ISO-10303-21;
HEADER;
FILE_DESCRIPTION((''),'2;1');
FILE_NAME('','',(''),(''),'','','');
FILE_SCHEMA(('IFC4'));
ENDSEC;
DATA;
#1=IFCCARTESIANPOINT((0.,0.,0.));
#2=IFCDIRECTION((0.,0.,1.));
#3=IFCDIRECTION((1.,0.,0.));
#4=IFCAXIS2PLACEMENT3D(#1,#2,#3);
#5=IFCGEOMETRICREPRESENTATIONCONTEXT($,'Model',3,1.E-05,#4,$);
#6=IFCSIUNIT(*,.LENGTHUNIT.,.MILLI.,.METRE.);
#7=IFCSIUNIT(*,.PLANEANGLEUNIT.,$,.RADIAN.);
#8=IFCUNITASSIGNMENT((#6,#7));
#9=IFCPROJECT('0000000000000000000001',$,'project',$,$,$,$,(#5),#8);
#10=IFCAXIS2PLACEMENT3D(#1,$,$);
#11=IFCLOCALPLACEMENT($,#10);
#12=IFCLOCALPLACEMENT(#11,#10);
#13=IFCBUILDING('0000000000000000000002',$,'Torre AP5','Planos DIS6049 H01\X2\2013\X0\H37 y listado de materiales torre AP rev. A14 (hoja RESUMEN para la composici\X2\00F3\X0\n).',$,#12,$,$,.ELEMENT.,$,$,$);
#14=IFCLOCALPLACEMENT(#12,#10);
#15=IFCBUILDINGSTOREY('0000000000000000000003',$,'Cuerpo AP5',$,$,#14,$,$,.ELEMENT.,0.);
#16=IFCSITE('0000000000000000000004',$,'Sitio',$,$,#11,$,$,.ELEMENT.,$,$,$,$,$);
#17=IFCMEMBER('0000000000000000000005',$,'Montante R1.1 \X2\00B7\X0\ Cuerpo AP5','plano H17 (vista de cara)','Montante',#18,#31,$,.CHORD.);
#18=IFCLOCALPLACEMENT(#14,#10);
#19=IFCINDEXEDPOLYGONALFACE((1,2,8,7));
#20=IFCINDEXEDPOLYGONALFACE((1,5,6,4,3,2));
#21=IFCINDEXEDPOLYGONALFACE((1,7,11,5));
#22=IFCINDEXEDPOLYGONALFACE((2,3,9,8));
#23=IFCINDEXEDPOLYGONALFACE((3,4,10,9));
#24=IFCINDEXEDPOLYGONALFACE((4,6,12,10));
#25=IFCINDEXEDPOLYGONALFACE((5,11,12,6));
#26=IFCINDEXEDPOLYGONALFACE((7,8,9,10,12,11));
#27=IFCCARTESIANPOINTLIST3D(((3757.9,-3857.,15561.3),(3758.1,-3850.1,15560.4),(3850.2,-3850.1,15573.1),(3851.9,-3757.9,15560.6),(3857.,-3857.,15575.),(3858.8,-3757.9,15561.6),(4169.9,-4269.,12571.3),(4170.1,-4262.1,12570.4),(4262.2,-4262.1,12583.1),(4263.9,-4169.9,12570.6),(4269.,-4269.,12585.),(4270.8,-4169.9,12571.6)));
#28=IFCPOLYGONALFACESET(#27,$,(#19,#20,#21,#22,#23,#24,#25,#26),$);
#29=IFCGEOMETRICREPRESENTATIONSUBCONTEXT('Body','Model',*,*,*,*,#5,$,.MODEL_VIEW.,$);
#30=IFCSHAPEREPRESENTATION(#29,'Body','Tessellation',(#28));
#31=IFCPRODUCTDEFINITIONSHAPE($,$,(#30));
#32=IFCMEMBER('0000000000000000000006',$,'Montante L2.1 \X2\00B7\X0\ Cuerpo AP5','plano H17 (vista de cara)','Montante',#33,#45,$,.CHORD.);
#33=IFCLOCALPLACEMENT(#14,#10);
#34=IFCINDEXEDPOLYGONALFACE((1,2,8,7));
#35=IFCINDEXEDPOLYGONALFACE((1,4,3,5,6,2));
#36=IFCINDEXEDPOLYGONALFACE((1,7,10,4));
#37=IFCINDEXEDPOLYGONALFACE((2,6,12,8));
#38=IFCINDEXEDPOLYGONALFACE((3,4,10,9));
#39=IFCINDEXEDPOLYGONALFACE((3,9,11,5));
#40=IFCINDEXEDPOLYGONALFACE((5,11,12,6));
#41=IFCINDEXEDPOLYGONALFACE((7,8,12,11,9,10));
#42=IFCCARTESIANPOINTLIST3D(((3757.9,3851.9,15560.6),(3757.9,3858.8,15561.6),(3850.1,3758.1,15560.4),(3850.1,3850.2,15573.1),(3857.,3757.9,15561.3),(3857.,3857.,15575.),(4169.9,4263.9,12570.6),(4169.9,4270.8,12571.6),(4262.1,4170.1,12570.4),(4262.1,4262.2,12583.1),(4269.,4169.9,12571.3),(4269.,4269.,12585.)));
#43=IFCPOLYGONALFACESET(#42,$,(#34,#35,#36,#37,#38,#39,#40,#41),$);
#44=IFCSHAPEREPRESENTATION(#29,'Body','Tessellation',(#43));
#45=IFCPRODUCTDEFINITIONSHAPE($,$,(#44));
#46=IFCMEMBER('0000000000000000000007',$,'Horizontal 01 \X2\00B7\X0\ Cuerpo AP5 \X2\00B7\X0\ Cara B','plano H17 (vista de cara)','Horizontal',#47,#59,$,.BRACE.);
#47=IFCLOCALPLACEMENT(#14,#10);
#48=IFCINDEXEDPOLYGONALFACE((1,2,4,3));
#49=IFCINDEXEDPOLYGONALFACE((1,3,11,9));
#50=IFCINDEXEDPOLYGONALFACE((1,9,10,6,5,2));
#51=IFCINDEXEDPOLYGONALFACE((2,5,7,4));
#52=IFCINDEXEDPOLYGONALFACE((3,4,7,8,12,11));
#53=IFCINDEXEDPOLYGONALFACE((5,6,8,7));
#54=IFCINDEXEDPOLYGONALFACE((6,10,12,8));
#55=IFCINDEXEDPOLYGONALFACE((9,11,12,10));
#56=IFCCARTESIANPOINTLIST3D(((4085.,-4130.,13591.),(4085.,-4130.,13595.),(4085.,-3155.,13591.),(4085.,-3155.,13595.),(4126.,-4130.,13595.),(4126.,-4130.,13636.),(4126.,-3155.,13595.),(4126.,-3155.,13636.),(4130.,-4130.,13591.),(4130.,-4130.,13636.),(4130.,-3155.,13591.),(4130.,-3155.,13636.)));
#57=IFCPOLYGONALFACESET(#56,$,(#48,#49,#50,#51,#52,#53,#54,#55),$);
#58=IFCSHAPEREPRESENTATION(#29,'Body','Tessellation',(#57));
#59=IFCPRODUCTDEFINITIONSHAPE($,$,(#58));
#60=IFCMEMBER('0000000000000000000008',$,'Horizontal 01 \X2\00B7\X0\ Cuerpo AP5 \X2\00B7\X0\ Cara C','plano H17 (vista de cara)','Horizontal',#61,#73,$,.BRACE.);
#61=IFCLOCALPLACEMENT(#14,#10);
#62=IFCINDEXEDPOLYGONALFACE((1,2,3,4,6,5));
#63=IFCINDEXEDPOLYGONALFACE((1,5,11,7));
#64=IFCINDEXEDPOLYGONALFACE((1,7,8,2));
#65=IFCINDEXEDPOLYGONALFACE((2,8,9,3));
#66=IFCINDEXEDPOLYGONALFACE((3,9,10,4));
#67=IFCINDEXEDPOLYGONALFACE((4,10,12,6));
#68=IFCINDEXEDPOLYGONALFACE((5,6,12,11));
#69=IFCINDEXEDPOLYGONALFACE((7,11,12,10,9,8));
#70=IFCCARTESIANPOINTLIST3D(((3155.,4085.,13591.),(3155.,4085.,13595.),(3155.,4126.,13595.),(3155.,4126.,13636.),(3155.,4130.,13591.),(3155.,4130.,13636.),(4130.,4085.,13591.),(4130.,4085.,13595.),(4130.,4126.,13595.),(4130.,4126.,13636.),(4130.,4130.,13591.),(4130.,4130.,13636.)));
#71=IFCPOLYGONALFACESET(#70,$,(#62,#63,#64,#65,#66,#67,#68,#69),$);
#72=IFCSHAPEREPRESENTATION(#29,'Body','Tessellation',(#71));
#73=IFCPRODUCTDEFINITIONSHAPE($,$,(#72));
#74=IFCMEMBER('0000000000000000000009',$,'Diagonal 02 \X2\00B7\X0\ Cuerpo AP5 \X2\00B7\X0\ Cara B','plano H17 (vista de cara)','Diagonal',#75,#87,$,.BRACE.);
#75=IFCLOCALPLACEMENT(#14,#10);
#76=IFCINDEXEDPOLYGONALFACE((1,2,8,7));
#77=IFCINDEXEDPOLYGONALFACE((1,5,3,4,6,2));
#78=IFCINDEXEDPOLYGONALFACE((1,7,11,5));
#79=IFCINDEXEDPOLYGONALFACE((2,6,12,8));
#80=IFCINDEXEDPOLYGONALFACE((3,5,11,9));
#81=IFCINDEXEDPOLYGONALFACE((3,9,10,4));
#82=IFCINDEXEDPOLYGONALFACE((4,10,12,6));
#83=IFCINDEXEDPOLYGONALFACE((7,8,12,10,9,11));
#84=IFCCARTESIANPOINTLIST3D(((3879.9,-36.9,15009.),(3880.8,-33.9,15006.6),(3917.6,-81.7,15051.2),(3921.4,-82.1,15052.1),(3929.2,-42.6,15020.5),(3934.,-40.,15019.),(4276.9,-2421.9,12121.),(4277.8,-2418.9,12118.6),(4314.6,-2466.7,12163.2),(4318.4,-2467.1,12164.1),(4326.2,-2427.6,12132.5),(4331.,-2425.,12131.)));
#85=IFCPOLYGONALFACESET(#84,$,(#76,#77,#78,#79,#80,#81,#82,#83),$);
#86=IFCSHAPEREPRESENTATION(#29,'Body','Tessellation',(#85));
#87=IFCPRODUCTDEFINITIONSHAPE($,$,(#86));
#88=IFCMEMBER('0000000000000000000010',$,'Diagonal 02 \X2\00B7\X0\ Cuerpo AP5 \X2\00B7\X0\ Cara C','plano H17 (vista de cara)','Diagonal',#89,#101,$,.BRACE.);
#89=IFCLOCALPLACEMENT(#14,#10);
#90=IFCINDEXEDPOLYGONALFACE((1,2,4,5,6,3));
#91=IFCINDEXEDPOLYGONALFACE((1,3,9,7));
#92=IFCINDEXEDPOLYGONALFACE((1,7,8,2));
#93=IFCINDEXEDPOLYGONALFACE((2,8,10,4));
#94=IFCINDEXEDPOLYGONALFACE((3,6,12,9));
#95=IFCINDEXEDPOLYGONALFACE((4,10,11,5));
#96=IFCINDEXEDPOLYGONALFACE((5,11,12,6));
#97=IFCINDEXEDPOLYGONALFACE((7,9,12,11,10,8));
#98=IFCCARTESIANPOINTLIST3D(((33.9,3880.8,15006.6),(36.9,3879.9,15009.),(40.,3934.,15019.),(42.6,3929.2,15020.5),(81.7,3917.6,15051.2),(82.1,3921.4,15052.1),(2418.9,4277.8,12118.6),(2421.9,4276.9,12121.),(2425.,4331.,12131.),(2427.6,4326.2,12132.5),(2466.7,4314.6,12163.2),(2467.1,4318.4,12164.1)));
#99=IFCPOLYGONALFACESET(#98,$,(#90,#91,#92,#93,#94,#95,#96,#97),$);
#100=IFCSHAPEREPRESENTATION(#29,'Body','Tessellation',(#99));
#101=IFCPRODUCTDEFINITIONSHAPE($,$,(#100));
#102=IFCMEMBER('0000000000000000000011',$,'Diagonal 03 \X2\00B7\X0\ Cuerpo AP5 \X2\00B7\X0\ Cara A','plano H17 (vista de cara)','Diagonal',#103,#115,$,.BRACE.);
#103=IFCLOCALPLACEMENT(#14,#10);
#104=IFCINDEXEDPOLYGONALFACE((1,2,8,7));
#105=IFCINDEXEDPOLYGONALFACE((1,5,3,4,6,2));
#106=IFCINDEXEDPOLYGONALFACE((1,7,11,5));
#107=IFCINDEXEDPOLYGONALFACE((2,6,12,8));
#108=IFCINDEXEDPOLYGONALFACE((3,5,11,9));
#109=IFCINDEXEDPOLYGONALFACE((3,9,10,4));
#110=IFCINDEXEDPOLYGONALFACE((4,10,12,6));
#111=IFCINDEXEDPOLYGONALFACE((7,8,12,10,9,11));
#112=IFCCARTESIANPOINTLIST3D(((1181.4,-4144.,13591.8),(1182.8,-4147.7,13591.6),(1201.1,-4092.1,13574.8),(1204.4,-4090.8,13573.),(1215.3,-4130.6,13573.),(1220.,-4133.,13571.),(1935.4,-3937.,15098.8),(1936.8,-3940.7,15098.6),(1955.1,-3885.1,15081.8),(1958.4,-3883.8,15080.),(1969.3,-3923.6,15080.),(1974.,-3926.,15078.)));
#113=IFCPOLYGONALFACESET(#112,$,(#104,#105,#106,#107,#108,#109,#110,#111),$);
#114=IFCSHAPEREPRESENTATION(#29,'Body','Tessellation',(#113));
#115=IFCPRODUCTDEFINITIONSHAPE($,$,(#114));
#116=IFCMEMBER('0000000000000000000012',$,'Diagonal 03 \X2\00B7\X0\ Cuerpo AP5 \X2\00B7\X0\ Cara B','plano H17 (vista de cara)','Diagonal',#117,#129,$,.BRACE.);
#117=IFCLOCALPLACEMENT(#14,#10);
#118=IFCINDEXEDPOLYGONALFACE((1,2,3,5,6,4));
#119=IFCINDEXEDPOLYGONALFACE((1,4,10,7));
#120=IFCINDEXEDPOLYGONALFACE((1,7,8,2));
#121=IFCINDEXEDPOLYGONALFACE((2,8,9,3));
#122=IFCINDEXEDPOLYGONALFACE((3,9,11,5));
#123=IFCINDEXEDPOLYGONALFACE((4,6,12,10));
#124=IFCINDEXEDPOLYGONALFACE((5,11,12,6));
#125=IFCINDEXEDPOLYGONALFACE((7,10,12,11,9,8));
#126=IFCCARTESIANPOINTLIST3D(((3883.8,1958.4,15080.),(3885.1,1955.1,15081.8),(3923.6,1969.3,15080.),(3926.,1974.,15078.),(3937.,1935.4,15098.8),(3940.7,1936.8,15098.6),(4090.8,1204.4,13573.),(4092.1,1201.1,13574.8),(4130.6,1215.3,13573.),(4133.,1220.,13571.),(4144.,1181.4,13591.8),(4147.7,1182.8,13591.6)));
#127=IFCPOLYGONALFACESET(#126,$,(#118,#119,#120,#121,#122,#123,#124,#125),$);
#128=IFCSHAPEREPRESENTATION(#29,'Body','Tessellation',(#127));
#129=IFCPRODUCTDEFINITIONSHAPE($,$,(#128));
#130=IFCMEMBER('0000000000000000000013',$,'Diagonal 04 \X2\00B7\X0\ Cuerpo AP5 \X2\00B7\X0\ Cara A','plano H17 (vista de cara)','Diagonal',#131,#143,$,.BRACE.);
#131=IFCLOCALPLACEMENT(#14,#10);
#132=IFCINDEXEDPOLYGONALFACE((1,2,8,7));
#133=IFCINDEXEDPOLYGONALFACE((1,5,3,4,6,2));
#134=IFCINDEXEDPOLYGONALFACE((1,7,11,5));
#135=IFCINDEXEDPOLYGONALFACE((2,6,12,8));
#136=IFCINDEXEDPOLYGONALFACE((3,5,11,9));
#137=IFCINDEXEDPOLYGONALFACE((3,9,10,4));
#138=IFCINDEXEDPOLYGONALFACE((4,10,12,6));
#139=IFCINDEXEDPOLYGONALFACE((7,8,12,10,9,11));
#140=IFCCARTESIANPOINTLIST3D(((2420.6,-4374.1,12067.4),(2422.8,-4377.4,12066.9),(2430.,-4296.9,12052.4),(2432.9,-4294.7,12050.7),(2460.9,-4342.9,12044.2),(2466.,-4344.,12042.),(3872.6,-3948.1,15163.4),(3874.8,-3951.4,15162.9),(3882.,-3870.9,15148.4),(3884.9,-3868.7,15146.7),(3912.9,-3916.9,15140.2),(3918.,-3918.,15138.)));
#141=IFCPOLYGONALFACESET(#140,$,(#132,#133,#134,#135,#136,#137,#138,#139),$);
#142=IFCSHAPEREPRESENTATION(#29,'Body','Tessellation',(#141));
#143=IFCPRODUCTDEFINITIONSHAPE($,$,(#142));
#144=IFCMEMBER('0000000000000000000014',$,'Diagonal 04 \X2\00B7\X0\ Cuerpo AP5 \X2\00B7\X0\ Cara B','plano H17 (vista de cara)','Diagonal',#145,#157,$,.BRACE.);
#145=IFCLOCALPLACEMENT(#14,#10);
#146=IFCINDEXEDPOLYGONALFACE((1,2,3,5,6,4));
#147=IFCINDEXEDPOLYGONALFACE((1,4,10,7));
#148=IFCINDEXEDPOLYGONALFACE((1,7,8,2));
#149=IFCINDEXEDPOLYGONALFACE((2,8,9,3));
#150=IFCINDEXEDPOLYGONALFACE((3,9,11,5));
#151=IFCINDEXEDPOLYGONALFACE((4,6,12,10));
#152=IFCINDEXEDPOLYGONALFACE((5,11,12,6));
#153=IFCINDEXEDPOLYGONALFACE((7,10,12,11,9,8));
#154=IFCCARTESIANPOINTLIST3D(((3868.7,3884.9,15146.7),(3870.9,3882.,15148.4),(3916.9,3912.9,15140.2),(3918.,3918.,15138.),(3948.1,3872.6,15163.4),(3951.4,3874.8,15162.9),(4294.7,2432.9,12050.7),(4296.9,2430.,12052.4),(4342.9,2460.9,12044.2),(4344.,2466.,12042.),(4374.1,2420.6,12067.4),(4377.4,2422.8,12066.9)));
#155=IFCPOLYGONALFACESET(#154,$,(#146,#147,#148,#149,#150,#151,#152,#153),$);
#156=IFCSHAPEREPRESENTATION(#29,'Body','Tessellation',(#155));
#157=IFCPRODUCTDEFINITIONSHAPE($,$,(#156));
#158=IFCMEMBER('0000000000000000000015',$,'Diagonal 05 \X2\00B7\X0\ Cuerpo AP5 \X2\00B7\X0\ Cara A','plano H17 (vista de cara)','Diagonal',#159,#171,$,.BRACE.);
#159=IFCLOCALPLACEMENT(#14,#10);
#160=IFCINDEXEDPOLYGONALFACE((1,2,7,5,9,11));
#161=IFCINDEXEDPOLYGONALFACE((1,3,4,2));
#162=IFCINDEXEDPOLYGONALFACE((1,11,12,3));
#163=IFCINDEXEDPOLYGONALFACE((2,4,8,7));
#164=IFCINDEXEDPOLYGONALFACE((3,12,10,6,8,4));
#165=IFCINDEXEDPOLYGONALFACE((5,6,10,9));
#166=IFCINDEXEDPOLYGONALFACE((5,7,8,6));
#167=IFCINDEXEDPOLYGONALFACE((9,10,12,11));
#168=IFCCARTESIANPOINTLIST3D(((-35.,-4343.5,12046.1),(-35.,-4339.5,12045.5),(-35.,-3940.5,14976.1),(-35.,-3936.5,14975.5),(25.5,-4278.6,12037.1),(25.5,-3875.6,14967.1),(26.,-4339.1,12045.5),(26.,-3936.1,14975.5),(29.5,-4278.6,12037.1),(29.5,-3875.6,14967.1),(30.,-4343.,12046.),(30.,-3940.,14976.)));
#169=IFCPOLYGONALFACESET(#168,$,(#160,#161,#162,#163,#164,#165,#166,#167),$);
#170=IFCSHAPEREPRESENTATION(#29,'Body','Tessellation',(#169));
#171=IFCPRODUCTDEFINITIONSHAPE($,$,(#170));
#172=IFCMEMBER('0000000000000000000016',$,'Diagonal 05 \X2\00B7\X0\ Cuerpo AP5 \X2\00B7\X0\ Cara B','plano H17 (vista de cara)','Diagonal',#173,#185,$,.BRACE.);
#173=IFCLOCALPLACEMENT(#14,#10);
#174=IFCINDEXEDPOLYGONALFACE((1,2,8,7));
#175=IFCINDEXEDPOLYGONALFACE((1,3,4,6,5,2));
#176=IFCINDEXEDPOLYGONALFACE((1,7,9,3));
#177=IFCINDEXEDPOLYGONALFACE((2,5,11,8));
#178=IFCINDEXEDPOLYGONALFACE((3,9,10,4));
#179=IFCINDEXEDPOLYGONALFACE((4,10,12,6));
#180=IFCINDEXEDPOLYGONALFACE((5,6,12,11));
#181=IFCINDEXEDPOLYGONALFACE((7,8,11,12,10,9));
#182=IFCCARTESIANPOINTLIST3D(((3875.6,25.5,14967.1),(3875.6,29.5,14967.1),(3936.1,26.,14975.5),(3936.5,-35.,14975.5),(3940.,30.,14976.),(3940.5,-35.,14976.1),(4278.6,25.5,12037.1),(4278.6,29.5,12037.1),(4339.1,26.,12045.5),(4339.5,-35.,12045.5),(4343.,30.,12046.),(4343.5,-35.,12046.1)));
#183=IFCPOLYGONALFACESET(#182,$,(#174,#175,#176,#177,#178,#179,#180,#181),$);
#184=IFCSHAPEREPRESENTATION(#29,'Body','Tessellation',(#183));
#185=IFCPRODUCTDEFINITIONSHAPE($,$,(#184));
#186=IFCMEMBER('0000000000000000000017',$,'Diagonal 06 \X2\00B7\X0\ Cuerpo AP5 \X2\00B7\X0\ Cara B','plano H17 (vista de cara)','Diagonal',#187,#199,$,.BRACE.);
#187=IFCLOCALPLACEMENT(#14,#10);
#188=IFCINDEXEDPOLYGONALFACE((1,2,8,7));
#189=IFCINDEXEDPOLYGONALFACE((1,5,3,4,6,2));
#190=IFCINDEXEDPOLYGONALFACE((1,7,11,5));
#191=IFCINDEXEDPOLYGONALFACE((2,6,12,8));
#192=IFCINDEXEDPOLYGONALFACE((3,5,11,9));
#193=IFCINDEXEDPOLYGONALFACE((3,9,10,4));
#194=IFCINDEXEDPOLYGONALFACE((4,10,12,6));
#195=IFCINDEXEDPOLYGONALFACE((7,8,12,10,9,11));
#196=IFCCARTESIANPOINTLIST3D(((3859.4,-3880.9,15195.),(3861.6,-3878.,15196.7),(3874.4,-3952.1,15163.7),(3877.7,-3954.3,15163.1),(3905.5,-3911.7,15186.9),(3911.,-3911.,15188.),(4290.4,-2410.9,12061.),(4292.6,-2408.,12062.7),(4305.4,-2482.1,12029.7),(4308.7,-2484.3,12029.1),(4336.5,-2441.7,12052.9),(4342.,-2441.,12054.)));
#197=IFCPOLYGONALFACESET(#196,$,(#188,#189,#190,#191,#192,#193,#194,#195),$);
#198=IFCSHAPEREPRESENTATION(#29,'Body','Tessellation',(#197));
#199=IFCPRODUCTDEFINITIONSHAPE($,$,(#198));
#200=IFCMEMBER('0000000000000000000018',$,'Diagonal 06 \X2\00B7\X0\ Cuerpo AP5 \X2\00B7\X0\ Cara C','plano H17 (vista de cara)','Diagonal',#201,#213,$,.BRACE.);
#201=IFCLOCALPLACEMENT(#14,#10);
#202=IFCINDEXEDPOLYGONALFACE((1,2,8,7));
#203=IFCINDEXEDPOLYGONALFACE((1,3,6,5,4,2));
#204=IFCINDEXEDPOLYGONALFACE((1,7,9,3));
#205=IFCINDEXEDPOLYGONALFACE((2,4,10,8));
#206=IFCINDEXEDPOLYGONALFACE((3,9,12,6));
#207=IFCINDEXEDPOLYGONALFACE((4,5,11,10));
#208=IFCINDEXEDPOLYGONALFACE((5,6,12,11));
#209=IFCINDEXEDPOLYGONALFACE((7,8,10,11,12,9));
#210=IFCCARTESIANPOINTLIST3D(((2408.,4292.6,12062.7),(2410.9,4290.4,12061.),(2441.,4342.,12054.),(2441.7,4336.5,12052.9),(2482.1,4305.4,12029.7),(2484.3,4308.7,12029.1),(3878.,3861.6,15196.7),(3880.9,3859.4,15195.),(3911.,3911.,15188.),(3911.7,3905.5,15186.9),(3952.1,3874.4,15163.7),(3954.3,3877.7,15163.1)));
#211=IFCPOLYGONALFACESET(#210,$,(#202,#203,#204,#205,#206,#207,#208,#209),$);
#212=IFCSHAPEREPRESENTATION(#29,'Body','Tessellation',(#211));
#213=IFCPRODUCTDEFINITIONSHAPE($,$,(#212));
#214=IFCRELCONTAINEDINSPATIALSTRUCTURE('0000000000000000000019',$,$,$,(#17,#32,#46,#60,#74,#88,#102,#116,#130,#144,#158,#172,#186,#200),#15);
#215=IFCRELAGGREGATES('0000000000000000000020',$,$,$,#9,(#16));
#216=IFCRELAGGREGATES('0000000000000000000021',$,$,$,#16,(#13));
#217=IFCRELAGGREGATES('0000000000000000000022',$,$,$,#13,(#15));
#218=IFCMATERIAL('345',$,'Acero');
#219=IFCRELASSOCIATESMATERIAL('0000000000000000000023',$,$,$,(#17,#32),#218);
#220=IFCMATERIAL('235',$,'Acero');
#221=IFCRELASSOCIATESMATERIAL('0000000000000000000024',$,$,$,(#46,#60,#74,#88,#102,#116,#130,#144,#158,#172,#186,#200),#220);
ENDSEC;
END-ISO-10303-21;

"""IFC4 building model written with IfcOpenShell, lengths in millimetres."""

from ifc_helpers import new_model, si_unit, frame, frame_2d, origin, origin_with_axes, place, context, subcontext, project, spatial, l_section, extrude, material, element, save


model = new_model("IFC4")

# Units and contexts
model_context = context("Model", 3, precision=1e-05, world=origin_with_axes())
body_context = subcontext(model_context, "Body", "Model", "MODEL_VIEW")
ifc_project = project(units=[si_unit("LENGTHUNIT", "METRE", prefix="MILLI"), si_unit("PLANEANGLEUNIT", "RADIAN")], contexts=[model_context])

# Site, building, storey
site_placement = place(None, origin())
site = spatial("IfcSite", under=ifc_project, at=site_placement, Name="Sitio", CompositionType="ELEMENT")
building_placement = place(site_placement, origin())
building = spatial("IfcBuilding", under=site, at=building_placement, Name="Torre AP5", Description="Planos DIS6049 H01–H37 y listado de materiales torre AP rev. A14 (hoja RESUMEN para la composición).", CompositionType="ELEMENT")
storey_placement = place(building_placement, origin())
storey = spatial("IfcBuildingStorey", under=building, at=storey_placement, Name="Cuerpo AP5", CompositionType="ELEMENT", Elevation=0.0)

# Members
ifc_material_1 = material(Name="345", Category="Acero")
for number, where, z_axis, x_axis, name in (
    (1, (4269.0, -4269.0, 12585.0), (-0.135249, 0.135249, 0.981537), (0.018462, 0.990812, -0.133983), "Montante R1.1 · Cuerpo AP5"),
    (2, (4269.0, 4269.0, 12585.0), (-0.135249, -0.135249, 0.981537), (-0.990812, 0.018462, -0.133983), "Montante L2.1 · Cuerpo AP5"),
):
    element("IfcMember", number, at=place(storey_placement, frame(where, z_axis=z_axis, x_axis=x_axis)), inside=storey, material=ifc_material_1, Name=name, Description="plano H17 (vista de cara)", ObjectType="Montante", PredefinedType="CHORD", context=body_context, shape_type="SweptSolid", body=[
        extrude(l_section(Depth=100.0, Width=100.0, Thickness=7.0, at=frame_2d((50.0, 50.0))), None, (0.0, 0.0, 1.0), 3046.2),
    ])
ifc_material_2 = material(Name="235", Category="Acero")
for number, where, z_axis, x_axis, name in (
    (3, (4130.0, -4130.0, 13591.0), (0.0, 1.0, 0.0), (-1.0, 0.0, 0.0), "Horizontal 01 · Cuerpo AP5 · Cara B"),
    (4, (4130.0, 4130.0, 13591.0), (-1.0, 0.0, 0.0), (0.0, -1.0, 0.0), "Horizontal 01 · Cuerpo AP5 · Cara C"),
):
    element("IfcMember", number, at=place(storey_placement, frame(where, z_axis=z_axis, x_axis=x_axis)), inside=storey, material=ifc_material_2, Name=name, Description="plano H17 (vista de cara)", ObjectType="Horizontal", PredefinedType="BRACE", context=body_context, shape_type="SweptSolid", body=[
        extrude(l_section(Depth=45.0, Width=45.0, Thickness=4.0, at=frame_2d((22.5, 22.5))), None, (0.0, 0.0, 1.0), 975.0),
    ])
for number, where, z_axis, x_axis, name in (
    (5, (4331.0, -2425.0, 12131.0), (-0.105403, 0.633217, 0.766763), (-0.967841, 0.111785, -0.22536), "Diagonal 02 · Cuerpo AP5 · Cara B"),
    (6, (2425.0, 4331.0, 12131.0), (-0.633217, -0.105403, 0.766763), (-0.111785, -0.967841, -0.22536), "Diagonal 02 · Cuerpo AP5 · Cara C"),
):
    element("IfcMember", number, at=place(storey_placement, frame(where, z_axis=z_axis, x_axis=x_axis)), inside=storey, material=ifc_material_2, Name=name, Description="plano H17 (vista de cara)", ObjectType="Diagonal", PredefinedType="BRACE", context=body_context, shape_type="SweptSolid", body=[
        extrude(l_section(Depth=55.0, Width=55.0, Thickness=4.0, at=frame_2d((27.5, 27.5))), None, (0.0, 0.0, 1.0), 3766.5),
    ])
for number, where, z_axis, x_axis, name in (
    (7, (1220.0, -4133.0, 13571.0), (0.444113, 0.121925, 0.887636), (-0.346552, 0.936966, 0.04469), "Diagonal 03 · Cuerpo AP5 · Cara A"),
    (8, (4133.0, 1220.0, 13571.0), (-0.121925, 0.444113, 0.887636), (-0.936966, -0.346552, 0.04469), "Diagonal 03 · Cuerpo AP5 · Cara B"),
):
    element("IfcMember", number, at=place(storey_placement, frame(where, z_axis=z_axis, x_axis=x_axis)), inside=storey, material=ifc_material_2, Name=name, Description="plano H17 (vista de cara)", ObjectType="Diagonal", PredefinedType="BRACE", context=body_context, shape_type="SweptSolid", body=[
        extrude(l_section(Depth=45.0, Width=45.0, Thickness=4.0, at=frame_2d((22.5, 22.5))), None, (0.0, 0.0, 1.0), 1697.8),
    ])
for number, where, z_axis, x_axis, name in (
    (9, (2466.0, -4344.0, 12042.0), (0.421357, 0.123621, 0.89843), (-0.551178, 0.821613, 0.145447), "Diagonal 04 · Cuerpo AP5 · Cara A"),
    (10, (4344.0, 2466.0, 12042.0), (-0.123621, 0.421357, 0.89843), (-0.821613, -0.551178, 0.145447), "Diagonal 04 · Cuerpo AP5 · Cara B"),
):
    element("IfcMember", number, at=place(storey_placement, frame(where, z_axis=z_axis, x_axis=x_axis)), inside=storey, material=ifc_material_2, Name=name, Description="plano H17 (vista de cara)", ObjectType="Diagonal", PredefinedType="BRACE", context=body_context, shape_type="SweptSolid", body=[
        extrude(l_section(Depth=60.0, Width=60.0, Thickness=4.0, at=frame_2d((30.0, 30.0))), None, (0.0, 0.0, 1.0), 3446.0),
    ])
for number, where, z_axis, x_axis, name in (
    (11, (30.0, -4343.0, 12046.0), (0.0, 0.13626, 0.990673), (-0.007312, 0.990647, -0.136256), "Diagonal 05 · Cuerpo AP5 · Cara A"),
    (12, (4343.0, 30.0, 12046.0), (-0.13626, 0.0, 0.990673), (-0.990647, -0.007312, -0.136256), "Diagonal 05 · Cuerpo AP5 · Cara B"),
):
    element("IfcMember", number, at=place(storey_placement, frame(where, z_axis=z_axis, x_axis=x_axis)), inside=storey, material=ifc_material_2, Name=name, Description="plano H17 (vista de cara)", ObjectType="Diagonal", PredefinedType="BRACE", context=body_context, shape_type="SweptSolid", body=[
        extrude(l_section(Depth=65.0, Width=65.0, Thickness=4.0, at=frame_2d((32.5, 32.5))), None, (0.0, 0.0, 1.0), 2957.6),
    ])
for number, where, z_axis, x_axis, name in (
    (13, (4342.0, -2441.0, 12054.0), (-0.123554, -0.421402, 0.898418), (-0.822598, 0.549879, 0.144793), "Diagonal 06 · Cuerpo AP5 · Cara B"),
    (14, (2441.0, 4342.0, 12054.0), (0.421402, -0.123554, 0.898418), (-0.549879, -0.822598, 0.144793), "Diagonal 06 · Cuerpo AP5 · Cara C"),
):
    element("IfcMember", number, at=place(storey_placement, frame(where, z_axis=z_axis, x_axis=x_axis)), inside=storey, material=ifc_material_2, Name=name, Description="plano H17 (vista de cara)", ObjectType="Diagonal", PredefinedType="BRACE", context=body_context, shape_type="SweptSolid", body=[
        extrude(l_section(Depth=60.0, Width=60.0, Thickness=4.0, at=frame_2d((30.0, 30.0))), None, (0.0, 0.0, 1.0), 3488.4),
    ])

save(model, "model.ifc")
